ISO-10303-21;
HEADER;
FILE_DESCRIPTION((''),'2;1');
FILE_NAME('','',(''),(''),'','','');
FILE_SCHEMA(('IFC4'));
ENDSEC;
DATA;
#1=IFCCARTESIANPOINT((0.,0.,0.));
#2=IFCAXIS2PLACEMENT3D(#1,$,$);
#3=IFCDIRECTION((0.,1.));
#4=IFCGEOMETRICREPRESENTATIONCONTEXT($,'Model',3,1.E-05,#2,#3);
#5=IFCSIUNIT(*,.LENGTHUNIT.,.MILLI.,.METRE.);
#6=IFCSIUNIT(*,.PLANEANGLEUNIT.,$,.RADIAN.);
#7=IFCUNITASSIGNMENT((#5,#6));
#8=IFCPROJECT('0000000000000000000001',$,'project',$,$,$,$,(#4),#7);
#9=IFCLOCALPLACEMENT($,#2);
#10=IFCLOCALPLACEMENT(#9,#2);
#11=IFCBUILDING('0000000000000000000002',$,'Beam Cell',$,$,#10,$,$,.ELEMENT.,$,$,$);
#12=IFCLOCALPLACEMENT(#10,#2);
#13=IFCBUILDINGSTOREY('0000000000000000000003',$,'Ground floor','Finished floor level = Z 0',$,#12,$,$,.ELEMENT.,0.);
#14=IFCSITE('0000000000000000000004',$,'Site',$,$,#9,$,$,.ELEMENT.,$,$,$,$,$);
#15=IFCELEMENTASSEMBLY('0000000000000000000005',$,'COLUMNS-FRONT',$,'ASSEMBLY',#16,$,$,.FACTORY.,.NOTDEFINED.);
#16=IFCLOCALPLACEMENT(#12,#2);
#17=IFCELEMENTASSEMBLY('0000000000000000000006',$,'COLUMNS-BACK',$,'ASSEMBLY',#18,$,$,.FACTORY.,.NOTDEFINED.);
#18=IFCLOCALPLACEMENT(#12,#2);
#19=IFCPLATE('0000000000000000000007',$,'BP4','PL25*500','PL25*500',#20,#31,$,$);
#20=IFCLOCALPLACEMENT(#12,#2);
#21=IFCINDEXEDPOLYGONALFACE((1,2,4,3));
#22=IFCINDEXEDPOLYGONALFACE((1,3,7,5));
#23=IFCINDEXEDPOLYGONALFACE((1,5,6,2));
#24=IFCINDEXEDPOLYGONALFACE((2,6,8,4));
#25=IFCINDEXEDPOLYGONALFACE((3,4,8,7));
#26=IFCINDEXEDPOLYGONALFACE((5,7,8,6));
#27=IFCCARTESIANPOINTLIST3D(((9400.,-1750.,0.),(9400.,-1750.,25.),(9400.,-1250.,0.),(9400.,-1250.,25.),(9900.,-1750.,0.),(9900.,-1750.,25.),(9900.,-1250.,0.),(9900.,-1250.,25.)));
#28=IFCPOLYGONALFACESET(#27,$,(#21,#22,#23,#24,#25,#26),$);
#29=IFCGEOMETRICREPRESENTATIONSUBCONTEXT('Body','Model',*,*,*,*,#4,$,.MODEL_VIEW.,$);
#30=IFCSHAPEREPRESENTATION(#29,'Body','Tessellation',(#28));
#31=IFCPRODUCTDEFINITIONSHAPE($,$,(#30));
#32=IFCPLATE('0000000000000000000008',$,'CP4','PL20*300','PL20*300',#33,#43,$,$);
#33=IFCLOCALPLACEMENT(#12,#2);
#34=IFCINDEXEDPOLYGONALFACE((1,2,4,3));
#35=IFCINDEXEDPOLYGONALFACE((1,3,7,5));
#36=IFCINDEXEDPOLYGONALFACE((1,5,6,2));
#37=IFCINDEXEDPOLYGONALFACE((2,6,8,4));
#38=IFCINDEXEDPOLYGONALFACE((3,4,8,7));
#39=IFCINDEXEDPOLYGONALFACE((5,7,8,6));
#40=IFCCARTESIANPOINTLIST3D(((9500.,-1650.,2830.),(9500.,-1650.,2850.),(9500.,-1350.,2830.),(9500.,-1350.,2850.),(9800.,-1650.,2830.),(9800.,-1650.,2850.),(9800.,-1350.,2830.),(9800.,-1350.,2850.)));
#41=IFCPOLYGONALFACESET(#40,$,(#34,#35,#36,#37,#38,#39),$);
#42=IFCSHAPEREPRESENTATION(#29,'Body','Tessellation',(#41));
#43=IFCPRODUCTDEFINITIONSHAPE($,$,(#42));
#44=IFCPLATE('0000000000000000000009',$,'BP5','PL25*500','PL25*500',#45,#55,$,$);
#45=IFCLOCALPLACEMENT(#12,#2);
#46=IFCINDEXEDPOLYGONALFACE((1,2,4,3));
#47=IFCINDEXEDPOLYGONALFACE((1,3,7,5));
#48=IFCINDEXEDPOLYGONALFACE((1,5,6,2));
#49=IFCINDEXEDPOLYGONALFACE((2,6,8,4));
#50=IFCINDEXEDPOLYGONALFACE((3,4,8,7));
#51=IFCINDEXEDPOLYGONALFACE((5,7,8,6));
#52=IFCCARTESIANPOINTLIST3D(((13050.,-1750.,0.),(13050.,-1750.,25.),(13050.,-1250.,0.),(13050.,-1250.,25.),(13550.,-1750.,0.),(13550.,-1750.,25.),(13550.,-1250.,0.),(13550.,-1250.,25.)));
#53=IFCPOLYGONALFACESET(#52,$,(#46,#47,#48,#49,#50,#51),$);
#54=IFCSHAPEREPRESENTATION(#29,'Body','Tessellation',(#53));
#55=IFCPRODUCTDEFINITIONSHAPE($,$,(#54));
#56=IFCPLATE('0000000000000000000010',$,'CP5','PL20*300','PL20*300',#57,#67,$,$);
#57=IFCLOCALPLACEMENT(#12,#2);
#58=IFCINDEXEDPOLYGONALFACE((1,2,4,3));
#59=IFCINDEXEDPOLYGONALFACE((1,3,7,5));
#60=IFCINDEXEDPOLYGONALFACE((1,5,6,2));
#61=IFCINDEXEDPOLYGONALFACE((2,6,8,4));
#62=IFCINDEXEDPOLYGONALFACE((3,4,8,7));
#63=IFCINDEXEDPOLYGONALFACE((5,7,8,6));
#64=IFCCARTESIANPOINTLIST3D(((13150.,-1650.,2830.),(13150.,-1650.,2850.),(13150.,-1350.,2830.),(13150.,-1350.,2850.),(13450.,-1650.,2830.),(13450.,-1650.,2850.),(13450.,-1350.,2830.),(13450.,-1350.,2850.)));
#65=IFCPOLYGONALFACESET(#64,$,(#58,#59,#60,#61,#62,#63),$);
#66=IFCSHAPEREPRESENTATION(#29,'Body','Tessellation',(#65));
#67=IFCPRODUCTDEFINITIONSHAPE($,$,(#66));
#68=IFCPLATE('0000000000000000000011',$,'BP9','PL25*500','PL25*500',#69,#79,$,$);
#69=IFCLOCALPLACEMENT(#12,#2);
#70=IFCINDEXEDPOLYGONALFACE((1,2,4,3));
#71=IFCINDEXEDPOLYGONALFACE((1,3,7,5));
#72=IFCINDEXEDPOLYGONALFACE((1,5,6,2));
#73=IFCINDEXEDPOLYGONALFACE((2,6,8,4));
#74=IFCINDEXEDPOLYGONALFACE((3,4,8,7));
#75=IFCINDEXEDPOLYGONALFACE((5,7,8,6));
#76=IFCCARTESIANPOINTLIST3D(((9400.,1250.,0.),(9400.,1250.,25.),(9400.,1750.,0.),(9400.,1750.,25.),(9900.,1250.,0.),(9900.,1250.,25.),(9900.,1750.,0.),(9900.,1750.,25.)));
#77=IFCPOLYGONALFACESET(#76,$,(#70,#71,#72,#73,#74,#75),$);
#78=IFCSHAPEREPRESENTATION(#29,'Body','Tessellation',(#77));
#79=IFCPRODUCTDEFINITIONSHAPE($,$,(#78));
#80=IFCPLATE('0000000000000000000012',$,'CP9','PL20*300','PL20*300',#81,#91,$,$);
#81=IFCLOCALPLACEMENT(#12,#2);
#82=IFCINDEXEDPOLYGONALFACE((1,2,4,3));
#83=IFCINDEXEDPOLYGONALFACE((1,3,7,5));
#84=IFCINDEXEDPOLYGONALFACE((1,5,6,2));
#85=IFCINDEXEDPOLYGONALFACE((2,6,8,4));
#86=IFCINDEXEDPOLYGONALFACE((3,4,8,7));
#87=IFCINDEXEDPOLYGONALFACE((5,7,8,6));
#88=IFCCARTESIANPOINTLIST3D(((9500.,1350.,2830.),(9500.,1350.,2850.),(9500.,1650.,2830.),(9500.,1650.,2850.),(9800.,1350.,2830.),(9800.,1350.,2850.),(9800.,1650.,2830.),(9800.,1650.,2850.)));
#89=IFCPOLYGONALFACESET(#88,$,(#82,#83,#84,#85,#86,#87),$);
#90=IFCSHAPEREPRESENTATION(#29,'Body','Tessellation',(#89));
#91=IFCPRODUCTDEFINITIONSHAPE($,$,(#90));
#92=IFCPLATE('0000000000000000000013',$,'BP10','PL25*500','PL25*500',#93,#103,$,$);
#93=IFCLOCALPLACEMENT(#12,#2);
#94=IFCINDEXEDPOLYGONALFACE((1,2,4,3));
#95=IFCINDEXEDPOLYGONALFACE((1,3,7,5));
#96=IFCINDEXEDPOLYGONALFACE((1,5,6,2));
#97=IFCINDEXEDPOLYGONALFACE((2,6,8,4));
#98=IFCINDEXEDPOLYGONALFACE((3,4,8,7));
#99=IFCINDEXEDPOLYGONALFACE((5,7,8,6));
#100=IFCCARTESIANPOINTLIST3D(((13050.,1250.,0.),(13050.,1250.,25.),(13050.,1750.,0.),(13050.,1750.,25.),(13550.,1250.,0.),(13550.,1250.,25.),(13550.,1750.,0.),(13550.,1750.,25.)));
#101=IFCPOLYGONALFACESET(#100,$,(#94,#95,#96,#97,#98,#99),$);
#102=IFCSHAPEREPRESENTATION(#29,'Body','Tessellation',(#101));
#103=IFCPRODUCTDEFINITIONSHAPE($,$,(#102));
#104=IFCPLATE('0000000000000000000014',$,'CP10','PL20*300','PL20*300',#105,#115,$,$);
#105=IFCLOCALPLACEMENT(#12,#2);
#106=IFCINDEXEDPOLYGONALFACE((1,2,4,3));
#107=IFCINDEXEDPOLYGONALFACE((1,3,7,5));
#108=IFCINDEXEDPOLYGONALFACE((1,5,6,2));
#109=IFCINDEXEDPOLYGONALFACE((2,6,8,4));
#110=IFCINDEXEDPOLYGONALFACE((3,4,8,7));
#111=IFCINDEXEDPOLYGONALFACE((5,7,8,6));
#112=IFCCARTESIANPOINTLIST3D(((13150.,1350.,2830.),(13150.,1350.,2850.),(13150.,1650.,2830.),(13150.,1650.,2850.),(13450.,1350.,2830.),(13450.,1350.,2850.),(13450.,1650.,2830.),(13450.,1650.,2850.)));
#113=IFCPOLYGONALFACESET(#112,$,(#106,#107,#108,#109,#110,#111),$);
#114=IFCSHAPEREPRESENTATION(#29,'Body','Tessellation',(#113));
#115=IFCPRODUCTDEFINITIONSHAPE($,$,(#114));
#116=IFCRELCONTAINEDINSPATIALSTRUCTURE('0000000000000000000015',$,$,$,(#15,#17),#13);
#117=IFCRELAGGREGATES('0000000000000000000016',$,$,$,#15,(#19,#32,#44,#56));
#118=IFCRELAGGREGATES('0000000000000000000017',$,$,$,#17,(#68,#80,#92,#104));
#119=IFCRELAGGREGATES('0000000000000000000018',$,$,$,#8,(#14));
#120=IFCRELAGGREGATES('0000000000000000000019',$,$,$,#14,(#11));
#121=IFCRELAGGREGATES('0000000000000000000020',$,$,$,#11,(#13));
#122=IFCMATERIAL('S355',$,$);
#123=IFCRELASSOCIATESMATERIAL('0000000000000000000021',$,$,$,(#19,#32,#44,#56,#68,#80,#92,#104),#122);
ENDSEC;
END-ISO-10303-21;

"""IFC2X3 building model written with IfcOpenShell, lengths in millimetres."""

from ifc_helpers import new_model, si_unit, direction, frame, origin, origin_2d, place, context, subcontext, project, spatial, rectangle, extrude, material, element, aggregate, save


model = new_model("IFC2X3")

# Units and contexts
model_context = context("Model", 3, precision=1e-05, world=origin(), true_north=direction((0.0, 1.0)))
body_context = subcontext(model_context, "Body", "Model", "MODEL_VIEW")
ifc_project = project(units=[si_unit("LENGTHUNIT", "METRE", prefix="MILLI"), si_unit("PLANEANGLEUNIT", "RADIAN")], contexts=[model_context])

# Site, building, storey
site_placement = place(None, origin())
site = spatial("IfcSite", under=ifc_project, at=site_placement, Name="Site", CompositionType="ELEMENT")
building_placement = place(site_placement, origin())
building = spatial("IfcBuilding", under=site, at=building_placement, Name="Beam Cell", CompositionType="ELEMENT")
storey_placement = place(building_placement, origin())
storey = spatial("IfcBuildingStorey", under=building, at=storey_placement, Name="Ground floor", Description="Finished floor level = Z 0", CompositionType="ELEMENT", Elevation=0.0)

# Element assemblies
assembly_1_placement = place(storey_placement, origin())
assembly_1 = element("IfcElementAssembly", 1, at=assembly_1_placement, inside=storey, Name="COLUMNS-FRONT", ObjectType="ASSEMBLY", AssemblyPlace="FACTORY", PredefinedType="NOTDEFINED")
ifc_material = material(Name="S355")
assembly_2_placement = place(storey_placement, origin())
assembly_2 = element("IfcElementAssembly", 2, at=assembly_2_placement, inside=storey, Name="COLUMNS-BACK", ObjectType="ASSEMBLY", AssemblyPlace="FACTORY", PredefinedType="NOTDEFINED")

# Plates
plate_1_placement = place(storey_placement, frame((9650.0, -1500.0, 0.0), z_axis=(0.0, 0.0, 1.0), x_axis=(1.0, 0.0, 0.0)))
plate_1 = element("IfcPlate", 3, at=plate_1_placement, material=ifc_material, Name="BP4", Description="PL25*500", ObjectType="PL25*500", context=body_context, shape_type="SweptSolid", body=[
    extrude(rectangle(XDim=500.0, YDim=500.0, at=origin_2d()), origin(), (0.0, 0.0, 1.0), 25.0),
])
plate_2_placement = place(storey_placement, frame((9650.0, -1500.0, 2830.0), z_axis=(0.0, 0.0, 1.0), x_axis=(1.0, 0.0, 0.0)))
plate_2 = element("IfcPlate", 4, at=plate_2_placement, material=ifc_material, Name="CP4", Description="PL20*300", ObjectType="PL20*300", context=body_context, shape_type="SweptSolid", body=[
    extrude(rectangle(XDim=300.0, YDim=300.0, at=origin_2d()), origin(), (0.0, 0.0, 1.0), 20.0),
])
plate_3_placement = place(storey_placement, frame((13300.0, -1500.0, 0.0), z_axis=(0.0, 0.0, 1.0), x_axis=(1.0, 0.0, 0.0)))
plate_3 = element("IfcPlate", 5, at=plate_3_placement, material=ifc_material, Name="BP5", Description="PL25*500", ObjectType="PL25*500", context=body_context, shape_type="SweptSolid", body=[
    extrude(rectangle(XDim=500.0, YDim=500.0, at=origin_2d()), origin(), (0.0, 0.0, 1.0), 25.0),
])
plate_4_placement = place(storey_placement, frame((13300.0, -1500.0, 2830.0), z_axis=(0.0, 0.0, 1.0), x_axis=(1.0, 0.0, 0.0)))
plate_4 = element("IfcPlate", 6, at=plate_4_placement, material=ifc_material, Name="CP5", Description="PL20*300", ObjectType="PL20*300", context=body_context, shape_type="SweptSolid", body=[
    extrude(rectangle(XDim=300.0, YDim=300.0, at=origin_2d()), origin(), (0.0, 0.0, 1.0), 20.0),
])
aggregate(assembly_1, [plate_1, plate_2, plate_3, plate_4])
plate_5_placement = place(storey_placement, frame((9650.0, 1500.0, 0.0), z_axis=(0.0, 0.0, 1.0), x_axis=(1.0, 0.0, 0.0)))
plate_5 = element("IfcPlate", 7, at=plate_5_placement, material=ifc_material, Name="BP9", Description="PL25*500", ObjectType="PL25*500", context=body_context, shape_type="SweptSolid", body=[
    extrude(rectangle(XDim=500.0, YDim=500.0, at=origin_2d()), origin(), (0.0, 0.0, 1.0), 25.0),
])
plate_6_placement = place(storey_placement, frame((9650.0, 1500.0, 2830.0), z_axis=(0.0, 0.0, 1.0), x_axis=(1.0, 0.0, 0.0)))
plate_6 = element("IfcPlate", 8, at=plate_6_placement, material=ifc_material, Name="CP9", Description="PL20*300", ObjectType="PL20*300", context=body_context, shape_type="SweptSolid", body=[
    extrude(rectangle(XDim=300.0, YDim=300.0, at=origin_2d()), origin(), (0.0, 0.0, 1.0), 20.0),
])
plate_7_placement = place(storey_placement, frame((13300.0, 1500.0, 0.0), z_axis=(0.0, 0.0, 1.0), x_axis=(1.0, 0.0, 0.0)))
plate_7 = element("IfcPlate", 9, at=plate_7_placement, material=ifc_material, Name="BP10", Description="PL25*500", ObjectType="PL25*500", context=body_context, shape_type="SweptSolid", body=[
    extrude(rectangle(XDim=500.0, YDim=500.0, at=origin_2d()), origin(), (0.0, 0.0, 1.0), 25.0),
])
plate_8_placement = place(storey_placement, frame((13300.0, 1500.0, 2830.0), z_axis=(0.0, 0.0, 1.0), x_axis=(1.0, 0.0, 0.0)))
plate_8 = element("IfcPlate", 10, at=plate_8_placement, material=ifc_material, Name="CP10", Description="PL20*300", ObjectType="PL20*300", context=body_context, shape_type="SweptSolid", body=[
    extrude(rectangle(XDim=300.0, YDim=300.0, at=origin_2d()), origin(), (0.0, 0.0, 1.0), 20.0),
])
aggregate(assembly_2, [plate_5, plate_6, plate_7, plate_8])

save(model, "model.ifc")
